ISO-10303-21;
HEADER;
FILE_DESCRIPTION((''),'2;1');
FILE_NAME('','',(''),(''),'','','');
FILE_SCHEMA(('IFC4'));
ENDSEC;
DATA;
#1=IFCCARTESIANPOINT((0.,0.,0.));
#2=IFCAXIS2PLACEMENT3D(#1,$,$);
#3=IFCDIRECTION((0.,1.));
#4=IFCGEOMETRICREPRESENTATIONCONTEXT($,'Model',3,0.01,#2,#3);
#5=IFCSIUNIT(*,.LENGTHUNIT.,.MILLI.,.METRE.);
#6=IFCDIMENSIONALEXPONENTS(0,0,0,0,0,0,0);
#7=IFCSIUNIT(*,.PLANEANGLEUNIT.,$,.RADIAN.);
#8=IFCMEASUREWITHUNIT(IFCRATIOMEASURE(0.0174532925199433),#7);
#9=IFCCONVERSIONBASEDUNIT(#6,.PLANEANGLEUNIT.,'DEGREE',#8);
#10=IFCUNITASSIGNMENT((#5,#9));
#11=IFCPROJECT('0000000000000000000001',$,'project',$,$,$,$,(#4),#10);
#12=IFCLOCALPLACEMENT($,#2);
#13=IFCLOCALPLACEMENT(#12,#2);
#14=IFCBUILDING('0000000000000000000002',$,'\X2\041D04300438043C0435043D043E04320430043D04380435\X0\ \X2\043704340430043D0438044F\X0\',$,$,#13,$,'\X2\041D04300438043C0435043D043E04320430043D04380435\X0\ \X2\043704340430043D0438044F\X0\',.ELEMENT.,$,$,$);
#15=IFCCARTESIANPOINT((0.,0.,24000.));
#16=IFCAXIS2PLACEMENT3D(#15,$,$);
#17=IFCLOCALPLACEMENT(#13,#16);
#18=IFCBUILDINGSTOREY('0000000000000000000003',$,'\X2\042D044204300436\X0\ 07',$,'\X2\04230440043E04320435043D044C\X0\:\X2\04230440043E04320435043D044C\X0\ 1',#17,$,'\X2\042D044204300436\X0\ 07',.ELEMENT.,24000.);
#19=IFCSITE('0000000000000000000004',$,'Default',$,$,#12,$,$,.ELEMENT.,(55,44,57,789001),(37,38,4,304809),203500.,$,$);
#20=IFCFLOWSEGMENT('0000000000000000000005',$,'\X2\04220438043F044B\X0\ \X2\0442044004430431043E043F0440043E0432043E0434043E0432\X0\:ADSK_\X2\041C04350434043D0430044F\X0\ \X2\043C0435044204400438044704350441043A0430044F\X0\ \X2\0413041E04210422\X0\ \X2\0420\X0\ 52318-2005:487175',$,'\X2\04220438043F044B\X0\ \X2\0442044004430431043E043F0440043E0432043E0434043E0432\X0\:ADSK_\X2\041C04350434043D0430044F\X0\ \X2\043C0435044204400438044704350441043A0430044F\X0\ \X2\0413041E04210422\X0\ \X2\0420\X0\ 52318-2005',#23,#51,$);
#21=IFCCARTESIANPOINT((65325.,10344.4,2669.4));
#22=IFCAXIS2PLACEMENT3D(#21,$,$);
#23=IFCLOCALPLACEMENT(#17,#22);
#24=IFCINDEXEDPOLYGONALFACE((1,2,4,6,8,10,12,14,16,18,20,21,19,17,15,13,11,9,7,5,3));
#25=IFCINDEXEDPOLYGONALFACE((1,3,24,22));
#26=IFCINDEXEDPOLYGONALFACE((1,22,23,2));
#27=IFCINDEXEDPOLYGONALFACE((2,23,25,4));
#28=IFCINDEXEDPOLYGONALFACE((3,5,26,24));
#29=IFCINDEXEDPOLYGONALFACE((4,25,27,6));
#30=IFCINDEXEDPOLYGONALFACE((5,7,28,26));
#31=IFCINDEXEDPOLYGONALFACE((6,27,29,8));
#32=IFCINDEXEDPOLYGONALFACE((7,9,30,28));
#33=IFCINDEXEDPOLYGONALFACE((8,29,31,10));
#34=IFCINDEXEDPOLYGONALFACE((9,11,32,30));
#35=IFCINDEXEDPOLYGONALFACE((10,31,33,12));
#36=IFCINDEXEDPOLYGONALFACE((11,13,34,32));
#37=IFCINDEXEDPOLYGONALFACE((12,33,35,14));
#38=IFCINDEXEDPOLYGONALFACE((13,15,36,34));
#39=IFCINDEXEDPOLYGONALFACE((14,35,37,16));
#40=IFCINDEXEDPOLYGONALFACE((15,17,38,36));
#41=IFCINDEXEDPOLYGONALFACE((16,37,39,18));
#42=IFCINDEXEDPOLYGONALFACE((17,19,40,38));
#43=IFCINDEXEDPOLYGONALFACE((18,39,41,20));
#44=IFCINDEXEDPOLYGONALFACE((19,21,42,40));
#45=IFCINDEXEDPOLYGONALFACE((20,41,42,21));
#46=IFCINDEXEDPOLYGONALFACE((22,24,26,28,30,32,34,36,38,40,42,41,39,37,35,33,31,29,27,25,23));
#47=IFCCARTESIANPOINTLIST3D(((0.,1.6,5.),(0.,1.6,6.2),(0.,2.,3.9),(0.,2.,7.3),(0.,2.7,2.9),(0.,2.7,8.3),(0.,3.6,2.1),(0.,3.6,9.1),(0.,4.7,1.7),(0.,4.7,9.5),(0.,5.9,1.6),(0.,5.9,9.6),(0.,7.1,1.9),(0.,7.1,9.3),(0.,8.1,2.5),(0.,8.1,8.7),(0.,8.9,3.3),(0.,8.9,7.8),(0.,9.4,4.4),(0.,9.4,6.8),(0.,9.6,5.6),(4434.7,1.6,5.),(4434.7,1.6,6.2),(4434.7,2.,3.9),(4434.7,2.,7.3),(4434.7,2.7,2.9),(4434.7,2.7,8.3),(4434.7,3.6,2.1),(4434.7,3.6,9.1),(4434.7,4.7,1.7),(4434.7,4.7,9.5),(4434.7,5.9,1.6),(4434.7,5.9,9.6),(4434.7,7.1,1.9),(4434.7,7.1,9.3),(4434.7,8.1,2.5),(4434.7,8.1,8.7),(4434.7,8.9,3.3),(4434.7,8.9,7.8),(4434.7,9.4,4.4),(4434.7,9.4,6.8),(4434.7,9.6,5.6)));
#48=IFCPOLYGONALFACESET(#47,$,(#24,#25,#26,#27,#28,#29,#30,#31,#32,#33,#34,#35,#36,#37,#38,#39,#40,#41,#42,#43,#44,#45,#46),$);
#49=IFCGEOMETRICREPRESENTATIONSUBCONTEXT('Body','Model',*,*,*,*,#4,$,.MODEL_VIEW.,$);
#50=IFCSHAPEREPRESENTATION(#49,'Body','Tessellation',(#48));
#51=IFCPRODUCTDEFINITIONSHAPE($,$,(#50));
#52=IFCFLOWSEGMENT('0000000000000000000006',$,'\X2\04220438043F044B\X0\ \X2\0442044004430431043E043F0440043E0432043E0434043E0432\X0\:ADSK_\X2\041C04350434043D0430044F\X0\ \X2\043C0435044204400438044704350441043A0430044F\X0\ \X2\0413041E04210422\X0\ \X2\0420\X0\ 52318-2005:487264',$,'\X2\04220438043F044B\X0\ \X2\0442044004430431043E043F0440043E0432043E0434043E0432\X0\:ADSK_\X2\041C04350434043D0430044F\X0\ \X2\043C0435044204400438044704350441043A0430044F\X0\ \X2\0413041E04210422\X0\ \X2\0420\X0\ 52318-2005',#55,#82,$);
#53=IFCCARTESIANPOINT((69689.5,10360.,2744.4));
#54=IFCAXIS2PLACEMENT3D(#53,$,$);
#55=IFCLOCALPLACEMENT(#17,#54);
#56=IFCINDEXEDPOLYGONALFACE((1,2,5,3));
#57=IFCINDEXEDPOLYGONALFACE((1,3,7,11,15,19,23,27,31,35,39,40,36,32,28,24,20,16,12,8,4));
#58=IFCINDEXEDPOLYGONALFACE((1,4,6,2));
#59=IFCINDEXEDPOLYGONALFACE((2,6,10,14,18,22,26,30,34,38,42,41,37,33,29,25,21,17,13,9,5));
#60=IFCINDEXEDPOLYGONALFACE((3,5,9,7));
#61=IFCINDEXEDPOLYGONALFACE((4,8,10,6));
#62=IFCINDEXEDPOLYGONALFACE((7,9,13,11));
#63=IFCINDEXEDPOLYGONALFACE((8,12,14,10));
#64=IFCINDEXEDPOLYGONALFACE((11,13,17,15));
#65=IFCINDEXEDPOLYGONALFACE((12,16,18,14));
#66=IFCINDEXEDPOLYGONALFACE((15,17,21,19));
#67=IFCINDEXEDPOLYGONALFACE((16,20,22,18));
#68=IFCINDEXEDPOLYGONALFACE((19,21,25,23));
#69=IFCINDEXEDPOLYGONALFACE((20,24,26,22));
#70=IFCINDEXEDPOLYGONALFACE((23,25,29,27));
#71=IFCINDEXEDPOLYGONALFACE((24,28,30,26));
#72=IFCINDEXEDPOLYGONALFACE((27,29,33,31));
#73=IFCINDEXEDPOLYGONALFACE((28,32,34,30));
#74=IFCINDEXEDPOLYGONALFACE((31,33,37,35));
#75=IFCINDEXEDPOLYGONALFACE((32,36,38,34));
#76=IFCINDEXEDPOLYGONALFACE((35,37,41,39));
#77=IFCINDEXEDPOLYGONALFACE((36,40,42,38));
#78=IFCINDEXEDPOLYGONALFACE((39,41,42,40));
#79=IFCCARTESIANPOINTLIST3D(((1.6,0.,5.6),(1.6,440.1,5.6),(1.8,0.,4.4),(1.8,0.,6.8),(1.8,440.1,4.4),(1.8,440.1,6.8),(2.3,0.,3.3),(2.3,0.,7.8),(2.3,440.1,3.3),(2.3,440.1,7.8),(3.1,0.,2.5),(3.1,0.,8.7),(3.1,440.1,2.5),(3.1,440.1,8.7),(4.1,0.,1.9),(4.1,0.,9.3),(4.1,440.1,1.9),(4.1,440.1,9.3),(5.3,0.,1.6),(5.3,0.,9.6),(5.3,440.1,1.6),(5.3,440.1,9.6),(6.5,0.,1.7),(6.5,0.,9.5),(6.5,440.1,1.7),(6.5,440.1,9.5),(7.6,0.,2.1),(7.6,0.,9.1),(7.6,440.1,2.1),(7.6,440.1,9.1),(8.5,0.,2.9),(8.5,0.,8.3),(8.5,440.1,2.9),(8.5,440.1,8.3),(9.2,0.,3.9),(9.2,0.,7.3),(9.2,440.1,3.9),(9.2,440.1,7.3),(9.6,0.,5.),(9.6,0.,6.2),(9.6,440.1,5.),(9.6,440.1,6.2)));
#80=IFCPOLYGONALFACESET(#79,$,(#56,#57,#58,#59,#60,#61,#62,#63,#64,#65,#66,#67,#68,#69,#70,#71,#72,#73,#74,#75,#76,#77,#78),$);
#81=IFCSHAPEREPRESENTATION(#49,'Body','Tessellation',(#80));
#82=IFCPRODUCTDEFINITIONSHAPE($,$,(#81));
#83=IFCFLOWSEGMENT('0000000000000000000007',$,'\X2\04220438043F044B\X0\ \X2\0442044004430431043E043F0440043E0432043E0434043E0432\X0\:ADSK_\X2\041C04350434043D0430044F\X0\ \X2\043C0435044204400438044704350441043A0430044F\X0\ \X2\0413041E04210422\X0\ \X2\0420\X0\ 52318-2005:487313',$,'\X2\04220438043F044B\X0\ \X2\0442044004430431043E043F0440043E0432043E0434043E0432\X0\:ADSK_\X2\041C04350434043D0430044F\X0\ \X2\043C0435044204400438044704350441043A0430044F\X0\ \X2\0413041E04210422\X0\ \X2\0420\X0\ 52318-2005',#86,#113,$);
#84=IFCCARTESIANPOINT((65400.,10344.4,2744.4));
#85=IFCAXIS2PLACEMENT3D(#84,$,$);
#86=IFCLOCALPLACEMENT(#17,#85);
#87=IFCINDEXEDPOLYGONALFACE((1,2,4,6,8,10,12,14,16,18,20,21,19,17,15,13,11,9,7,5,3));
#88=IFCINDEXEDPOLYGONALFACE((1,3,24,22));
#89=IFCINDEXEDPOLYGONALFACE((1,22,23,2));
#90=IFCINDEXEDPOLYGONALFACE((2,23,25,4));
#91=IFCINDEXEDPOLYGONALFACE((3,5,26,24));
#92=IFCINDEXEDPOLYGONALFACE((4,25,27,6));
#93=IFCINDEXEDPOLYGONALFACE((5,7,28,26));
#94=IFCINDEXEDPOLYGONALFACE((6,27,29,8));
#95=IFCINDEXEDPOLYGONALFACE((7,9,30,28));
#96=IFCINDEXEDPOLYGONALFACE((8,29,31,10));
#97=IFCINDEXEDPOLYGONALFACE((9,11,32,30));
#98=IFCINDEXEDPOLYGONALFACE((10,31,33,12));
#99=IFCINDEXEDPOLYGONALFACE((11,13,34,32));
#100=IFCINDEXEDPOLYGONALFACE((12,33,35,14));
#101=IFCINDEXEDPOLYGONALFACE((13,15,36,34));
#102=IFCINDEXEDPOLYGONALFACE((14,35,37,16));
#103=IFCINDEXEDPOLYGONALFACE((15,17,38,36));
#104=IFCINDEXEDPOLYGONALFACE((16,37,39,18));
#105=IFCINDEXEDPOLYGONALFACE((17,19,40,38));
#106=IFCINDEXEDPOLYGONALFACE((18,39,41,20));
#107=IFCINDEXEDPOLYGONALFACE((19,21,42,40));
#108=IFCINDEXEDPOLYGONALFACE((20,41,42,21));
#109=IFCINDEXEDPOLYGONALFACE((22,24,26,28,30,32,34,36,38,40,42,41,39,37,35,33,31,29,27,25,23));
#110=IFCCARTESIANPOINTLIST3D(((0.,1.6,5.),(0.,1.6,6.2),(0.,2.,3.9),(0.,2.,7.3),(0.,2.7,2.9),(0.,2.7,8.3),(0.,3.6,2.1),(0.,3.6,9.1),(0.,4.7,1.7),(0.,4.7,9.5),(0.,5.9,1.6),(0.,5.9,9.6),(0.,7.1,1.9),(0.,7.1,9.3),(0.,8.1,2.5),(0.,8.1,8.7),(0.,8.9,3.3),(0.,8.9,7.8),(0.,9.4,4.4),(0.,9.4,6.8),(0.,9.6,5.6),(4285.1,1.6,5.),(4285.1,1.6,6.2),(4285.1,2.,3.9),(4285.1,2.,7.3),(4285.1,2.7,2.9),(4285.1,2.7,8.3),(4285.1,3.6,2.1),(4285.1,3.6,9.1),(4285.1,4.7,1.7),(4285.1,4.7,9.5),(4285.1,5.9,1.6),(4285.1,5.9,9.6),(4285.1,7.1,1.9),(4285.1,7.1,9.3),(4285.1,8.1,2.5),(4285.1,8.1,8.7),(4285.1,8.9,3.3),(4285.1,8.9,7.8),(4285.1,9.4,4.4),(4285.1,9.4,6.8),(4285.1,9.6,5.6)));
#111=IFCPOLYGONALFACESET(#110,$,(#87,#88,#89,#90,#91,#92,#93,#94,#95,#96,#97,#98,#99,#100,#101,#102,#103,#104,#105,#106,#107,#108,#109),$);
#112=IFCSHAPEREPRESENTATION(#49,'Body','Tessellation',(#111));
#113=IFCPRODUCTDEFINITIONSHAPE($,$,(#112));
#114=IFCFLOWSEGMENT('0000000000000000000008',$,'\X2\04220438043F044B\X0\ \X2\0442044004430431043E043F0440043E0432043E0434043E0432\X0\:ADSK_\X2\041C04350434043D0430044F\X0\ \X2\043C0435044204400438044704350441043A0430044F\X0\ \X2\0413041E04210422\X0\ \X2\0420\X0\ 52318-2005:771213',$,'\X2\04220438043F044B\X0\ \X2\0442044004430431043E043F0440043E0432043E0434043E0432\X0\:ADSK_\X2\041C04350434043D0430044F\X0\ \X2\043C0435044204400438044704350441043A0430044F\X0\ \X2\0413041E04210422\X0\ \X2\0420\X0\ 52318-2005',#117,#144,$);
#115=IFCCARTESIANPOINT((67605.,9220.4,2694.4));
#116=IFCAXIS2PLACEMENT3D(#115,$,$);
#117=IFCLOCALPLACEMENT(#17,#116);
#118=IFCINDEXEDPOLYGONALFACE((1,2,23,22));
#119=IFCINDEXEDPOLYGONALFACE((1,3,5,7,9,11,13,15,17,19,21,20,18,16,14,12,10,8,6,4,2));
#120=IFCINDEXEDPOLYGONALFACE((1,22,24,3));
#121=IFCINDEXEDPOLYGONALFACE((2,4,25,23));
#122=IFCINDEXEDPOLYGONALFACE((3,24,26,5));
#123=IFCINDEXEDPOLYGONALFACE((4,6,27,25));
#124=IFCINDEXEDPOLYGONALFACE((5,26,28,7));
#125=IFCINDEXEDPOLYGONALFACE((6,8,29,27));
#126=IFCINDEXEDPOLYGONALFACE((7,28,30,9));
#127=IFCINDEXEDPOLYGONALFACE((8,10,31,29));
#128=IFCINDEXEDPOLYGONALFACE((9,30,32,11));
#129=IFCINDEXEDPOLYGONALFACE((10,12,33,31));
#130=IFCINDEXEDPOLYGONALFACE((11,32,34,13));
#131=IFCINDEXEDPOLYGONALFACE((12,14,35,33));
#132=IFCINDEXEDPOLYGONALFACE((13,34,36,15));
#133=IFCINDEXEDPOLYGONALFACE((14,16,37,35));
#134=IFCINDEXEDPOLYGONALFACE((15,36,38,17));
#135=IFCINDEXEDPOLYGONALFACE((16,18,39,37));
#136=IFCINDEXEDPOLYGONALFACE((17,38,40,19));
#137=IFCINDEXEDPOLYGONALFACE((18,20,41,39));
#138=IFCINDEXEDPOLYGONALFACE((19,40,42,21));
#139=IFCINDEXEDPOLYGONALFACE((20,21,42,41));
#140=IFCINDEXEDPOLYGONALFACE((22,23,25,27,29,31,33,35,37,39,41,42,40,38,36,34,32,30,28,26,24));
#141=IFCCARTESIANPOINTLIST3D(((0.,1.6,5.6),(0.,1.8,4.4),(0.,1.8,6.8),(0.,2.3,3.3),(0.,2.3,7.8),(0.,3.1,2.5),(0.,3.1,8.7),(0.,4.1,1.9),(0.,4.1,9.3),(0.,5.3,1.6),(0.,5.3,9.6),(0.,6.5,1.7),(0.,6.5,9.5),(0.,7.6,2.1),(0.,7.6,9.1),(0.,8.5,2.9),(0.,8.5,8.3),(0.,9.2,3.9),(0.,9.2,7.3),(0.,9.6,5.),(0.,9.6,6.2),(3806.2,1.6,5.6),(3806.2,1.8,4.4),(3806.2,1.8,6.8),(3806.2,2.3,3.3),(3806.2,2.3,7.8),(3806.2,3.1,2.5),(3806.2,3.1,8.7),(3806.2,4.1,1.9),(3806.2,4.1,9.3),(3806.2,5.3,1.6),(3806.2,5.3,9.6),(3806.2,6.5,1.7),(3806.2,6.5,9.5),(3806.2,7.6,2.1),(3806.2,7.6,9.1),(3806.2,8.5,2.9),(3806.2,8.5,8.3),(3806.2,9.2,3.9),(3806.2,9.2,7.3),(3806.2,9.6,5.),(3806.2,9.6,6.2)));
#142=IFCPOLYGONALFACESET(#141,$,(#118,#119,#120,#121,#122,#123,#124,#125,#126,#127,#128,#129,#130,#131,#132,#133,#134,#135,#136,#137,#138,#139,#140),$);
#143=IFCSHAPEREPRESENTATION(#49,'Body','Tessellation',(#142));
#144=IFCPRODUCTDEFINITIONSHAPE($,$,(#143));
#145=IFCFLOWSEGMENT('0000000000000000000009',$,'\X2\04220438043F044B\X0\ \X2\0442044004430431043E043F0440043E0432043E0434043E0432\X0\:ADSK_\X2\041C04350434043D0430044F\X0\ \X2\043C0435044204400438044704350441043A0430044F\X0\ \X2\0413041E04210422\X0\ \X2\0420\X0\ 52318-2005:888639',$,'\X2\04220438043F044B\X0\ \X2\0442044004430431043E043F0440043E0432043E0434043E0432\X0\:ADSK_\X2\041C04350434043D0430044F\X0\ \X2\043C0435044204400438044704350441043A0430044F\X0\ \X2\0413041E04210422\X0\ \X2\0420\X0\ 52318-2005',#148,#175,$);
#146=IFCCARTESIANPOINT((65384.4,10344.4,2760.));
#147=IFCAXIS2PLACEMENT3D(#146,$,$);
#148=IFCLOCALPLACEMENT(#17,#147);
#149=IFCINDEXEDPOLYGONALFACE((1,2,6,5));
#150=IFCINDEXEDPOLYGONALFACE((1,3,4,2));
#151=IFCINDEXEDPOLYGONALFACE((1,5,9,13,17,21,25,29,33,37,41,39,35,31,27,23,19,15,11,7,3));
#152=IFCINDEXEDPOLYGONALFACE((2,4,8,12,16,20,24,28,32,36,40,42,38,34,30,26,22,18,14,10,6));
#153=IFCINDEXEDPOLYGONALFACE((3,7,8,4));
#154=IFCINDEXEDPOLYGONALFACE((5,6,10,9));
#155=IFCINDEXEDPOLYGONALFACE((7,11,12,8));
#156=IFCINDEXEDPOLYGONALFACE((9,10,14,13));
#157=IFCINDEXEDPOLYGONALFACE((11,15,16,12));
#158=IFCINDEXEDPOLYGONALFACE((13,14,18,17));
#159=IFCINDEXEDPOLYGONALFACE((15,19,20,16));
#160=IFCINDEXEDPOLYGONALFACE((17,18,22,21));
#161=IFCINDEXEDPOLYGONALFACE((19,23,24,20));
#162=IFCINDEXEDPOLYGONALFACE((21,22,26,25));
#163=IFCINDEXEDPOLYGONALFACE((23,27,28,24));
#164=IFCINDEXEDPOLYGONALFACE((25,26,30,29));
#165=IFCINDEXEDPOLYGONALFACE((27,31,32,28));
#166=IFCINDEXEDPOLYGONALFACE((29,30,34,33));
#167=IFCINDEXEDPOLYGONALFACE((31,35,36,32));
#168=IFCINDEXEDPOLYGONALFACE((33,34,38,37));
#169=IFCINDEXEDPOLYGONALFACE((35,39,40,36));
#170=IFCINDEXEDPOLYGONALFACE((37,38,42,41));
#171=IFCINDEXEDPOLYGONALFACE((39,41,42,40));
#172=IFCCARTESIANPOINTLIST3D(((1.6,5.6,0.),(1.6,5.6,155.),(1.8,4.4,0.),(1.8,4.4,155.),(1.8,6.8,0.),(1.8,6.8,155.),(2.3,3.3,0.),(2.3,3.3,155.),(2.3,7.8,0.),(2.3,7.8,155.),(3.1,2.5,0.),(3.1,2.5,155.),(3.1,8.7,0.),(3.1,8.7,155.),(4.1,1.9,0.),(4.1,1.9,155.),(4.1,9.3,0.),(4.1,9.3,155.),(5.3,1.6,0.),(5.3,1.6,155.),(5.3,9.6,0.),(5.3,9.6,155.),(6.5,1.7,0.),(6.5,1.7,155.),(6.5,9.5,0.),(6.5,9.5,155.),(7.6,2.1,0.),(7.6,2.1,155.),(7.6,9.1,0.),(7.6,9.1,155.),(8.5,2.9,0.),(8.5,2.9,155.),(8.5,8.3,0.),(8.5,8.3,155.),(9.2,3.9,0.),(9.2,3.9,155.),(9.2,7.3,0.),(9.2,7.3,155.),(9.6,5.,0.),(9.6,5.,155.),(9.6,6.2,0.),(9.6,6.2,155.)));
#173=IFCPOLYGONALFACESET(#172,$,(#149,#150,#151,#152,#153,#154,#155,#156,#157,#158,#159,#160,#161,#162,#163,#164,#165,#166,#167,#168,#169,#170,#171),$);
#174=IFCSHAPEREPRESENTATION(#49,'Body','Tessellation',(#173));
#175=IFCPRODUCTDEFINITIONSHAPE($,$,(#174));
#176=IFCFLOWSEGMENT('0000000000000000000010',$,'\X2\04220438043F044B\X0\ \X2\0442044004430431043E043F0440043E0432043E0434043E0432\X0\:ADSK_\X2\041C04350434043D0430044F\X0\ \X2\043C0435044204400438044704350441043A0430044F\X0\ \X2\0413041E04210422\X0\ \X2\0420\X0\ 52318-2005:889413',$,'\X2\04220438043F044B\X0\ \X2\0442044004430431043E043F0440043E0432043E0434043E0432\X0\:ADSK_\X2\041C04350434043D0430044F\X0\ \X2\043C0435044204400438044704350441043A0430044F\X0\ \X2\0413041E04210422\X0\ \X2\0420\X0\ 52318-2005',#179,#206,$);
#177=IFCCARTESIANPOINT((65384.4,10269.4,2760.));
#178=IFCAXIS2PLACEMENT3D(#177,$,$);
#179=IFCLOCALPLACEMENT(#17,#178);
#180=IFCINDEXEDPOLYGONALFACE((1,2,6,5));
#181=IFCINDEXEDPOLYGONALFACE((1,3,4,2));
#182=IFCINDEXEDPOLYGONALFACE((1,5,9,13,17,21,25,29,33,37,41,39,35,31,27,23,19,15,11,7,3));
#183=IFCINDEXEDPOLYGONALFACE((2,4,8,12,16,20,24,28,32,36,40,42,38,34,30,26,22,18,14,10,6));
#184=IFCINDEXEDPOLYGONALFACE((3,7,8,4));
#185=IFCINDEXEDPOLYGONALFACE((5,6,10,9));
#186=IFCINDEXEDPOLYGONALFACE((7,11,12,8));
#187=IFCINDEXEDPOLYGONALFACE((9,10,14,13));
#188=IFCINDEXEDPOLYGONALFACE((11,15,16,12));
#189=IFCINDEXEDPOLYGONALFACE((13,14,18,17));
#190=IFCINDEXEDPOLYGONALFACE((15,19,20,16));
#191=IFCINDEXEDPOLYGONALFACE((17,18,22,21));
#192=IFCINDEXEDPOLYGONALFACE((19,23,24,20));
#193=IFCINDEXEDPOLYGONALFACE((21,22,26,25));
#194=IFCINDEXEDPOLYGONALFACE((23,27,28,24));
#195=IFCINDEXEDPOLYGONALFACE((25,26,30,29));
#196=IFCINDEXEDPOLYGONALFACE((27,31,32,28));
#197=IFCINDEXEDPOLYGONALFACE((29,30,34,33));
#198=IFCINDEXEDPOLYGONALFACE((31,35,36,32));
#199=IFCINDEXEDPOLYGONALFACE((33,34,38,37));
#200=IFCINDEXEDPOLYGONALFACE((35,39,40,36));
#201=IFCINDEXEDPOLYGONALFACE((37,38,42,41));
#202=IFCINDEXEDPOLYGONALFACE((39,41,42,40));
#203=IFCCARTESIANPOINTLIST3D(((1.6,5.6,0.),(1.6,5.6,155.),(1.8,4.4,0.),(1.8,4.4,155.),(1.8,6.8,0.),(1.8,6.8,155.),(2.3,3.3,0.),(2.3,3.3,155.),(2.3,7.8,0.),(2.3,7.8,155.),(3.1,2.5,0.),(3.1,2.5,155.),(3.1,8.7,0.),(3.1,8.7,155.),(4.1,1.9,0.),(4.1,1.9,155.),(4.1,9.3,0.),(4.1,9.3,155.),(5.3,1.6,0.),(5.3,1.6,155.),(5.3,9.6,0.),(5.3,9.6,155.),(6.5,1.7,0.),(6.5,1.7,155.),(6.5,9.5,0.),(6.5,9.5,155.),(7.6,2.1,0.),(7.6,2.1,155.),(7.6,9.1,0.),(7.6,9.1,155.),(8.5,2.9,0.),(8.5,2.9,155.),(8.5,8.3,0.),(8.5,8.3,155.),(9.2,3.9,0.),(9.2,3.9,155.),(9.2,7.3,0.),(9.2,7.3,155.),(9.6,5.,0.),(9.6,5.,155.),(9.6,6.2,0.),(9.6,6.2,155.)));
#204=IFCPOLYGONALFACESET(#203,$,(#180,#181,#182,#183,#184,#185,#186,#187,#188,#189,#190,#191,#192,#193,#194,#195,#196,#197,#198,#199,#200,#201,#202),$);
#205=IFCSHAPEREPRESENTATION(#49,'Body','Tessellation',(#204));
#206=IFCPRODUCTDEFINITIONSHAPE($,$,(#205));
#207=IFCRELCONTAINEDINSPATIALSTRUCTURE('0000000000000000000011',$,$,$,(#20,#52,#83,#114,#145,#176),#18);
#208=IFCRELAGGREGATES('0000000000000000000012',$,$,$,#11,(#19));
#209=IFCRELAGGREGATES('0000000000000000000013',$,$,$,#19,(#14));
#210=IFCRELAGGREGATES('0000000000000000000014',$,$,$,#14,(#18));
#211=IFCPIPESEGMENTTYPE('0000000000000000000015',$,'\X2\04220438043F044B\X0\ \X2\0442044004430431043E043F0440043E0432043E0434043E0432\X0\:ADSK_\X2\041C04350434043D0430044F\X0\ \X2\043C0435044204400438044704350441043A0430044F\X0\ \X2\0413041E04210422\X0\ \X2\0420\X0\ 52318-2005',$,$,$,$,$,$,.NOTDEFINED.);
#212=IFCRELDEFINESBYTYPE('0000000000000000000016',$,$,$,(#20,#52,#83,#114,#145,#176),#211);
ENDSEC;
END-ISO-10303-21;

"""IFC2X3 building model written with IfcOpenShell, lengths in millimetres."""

from ifc_helpers import new_model, entity, si_unit, converted_unit, direction, frame, frame_2d, origin, origin_2d_with_axis, place, context, subcontext, project, spatial, circle, extrude, type_object, element, save


model = new_model("IFC2X3")

# Units and contexts
model_context = context("Model", 3, precision=0.01, world=origin(), true_north=direction((0.0, 1.0)))
body_context = subcontext(model_context, "Body", "Model", "MODEL_VIEW")
ifc_project = project(units=[si_unit("LENGTHUNIT", "METRE", prefix="MILLI"), converted_unit("PLANEANGLEUNIT", "DEGREE", entity("IfcRatioMeasure", 0.0174532925199433), si_unit("PLANEANGLEUNIT", "RADIAN"), dimensions=[0, 0, 0, 0, 0, 0, 0])], contexts=[model_context])

# Site, building, storey
site_placement = place(None, frame((0.0, 0.0, 0.0)))
site = spatial("IfcSite", under=ifc_project, at=site_placement, Name="Default", CompositionType="ELEMENT", RefLatitude=(55, 44, 57, 789001), RefLongitude=(37, 38, 4, 304809), RefElevation=203500.0)
building_placement = place(site_placement, origin())
building = spatial("IfcBuilding", under=site, at=building_placement, Name="Наименование здания", LongName="Наименование здания", CompositionType="ELEMENT")
storey_placement = place(building_placement, frame((0.0, 0.0, 24000.0)))
storey = spatial("IfcBuildingStorey", under=building, at=storey_placement, Name="Этаж 07", ObjectType="Уровень:Уровень 1", LongName="Этаж 07", CompositionType="ELEMENT", Elevation=24000.0)

# Flow segments
pipe_segment_type = type_object("IfcPipeSegmentType", Name="Типы трубопроводов:ADSK_Медная метрическая ГОСТ Р 52318-2005", PredefinedType="NOTDEFINED")
flow_segment_1_placement = place(storey_placement, frame((65325.0, 10344.4, 2669.4)))
element("IfcFlowSegment", 1, at=flow_segment_1_placement, inside=storey, type_object=pipe_segment_type, Name="Типы трубопроводов:ADSK_Медная метрическая ГОСТ Р 52318-2005:487175", ObjectType="Типы трубопроводов:ADSK_Медная метрическая ГОСТ Р 52318-2005", context=body_context, shape_type="SweptSolid", body=[
    extrude(circle(Radius=4.0, at=frame_2d((0.0, 0.0), x_axis=(1.0, 0.0))), frame((0.0, 5.6, 5.6), z_axis=(1.0, 0.0, 0.0), x_axis=(0.0, 1.0, 0.0)), (0.0, 0.0, 1.0), 4434.7),
])
flow_segment_2_placement = place(storey_placement, frame((69689.5, 10360.0, 2744.4)))
element("IfcFlowSegment", 2, at=flow_segment_2_placement, inside=storey, type_object=pipe_segment_type, Name="Типы трубопроводов:ADSK_Медная метрическая ГОСТ Р 52318-2005:487264", ObjectType="Типы трубопроводов:ADSK_Медная метрическая ГОСТ Р 52318-2005", context=body_context, shape_type="SweptSolid", body=[
    extrude(circle(Radius=4.0, at=frame_2d((0.0, 0.0), x_axis=(1.0, 0.0))), frame((5.6, 0.0, 5.6), z_axis=(0.0, 1.0, 0.0), x_axis=(-1.0, 0.0, 0.0)), (0.0, 0.0, 1.0), 440.1),
])
flow_segment_3_placement = place(storey_placement, frame((65400.0, 10344.4, 2744.4)))
element("IfcFlowSegment", 3, at=flow_segment_3_placement, inside=storey, type_object=pipe_segment_type, Name="Типы трубопроводов:ADSK_Медная метрическая ГОСТ Р 52318-2005:487313", ObjectType="Типы трубопроводов:ADSK_Медная метрическая ГОСТ Р 52318-2005", context=body_context, shape_type="SweptSolid", body=[
    extrude(circle(Radius=4.0, at=frame_2d((0.0, 0.0), x_axis=(1.0, 0.0))), frame((0.0, 5.6, 5.6), z_axis=(1.0, 0.0, 0.0), x_axis=(0.0, 1.0, 0.0)), (0.0, 0.0, 1.0), 4285.1),
])
flow_segment_4_placement = place(storey_placement, frame((67605.0, 9220.4, 2694.4)))
element("IfcFlowSegment", 4, at=flow_segment_4_placement, inside=storey, type_object=pipe_segment_type, Name="Типы трубопроводов:ADSK_Медная метрическая ГОСТ Р 52318-2005:771213", ObjectType="Типы трубопроводов:ADSK_Медная метрическая ГОСТ Р 52318-2005", context=body_context, shape_type="SweptSolid", body=[
    extrude(circle(Radius=4.0, at=origin_2d_with_axis()), frame((0.0, 5.6, 5.6), z_axis=(1.0, 0.0, 0.0), x_axis=(0.0, -1.0, 0.0)), (0.0, 0.0, 1.0), 3806.2),
])
flow_segment_5_placement = place(storey_placement, frame((65384.4, 10344.4, 2760.0)))
element("IfcFlowSegment", 5, at=flow_segment_5_placement, inside=storey, type_object=pipe_segment_type, Name="Типы трубопроводов:ADSK_Медная метрическая ГОСТ Р 52318-2005:888639", ObjectType="Типы трубопроводов:ADSK_Медная метрическая ГОСТ Р 52318-2005", context=body_context, shape_type="SweptSolid", body=[
    extrude(circle(Radius=4.0, at=origin_2d_with_axis()), frame((5.6, 5.6, 0.0), z_axis=(0.0, 0.0, 1.0), x_axis=(-1.0, 0.0, 0.0)), (0.0, 0.0, 1.0), 155.0),
])
flow_segment_6_placement = place(storey_placement, frame((65384.4, 10269.4, 2760.0)))
element("IfcFlowSegment", 6, at=flow_segment_6_placement, inside=storey, type_object=pipe_segment_type, Name="Типы трубопроводов:ADSK_Медная метрическая ГОСТ Р 52318-2005:889413", ObjectType="Типы трубопроводов:ADSK_Медная метрическая ГОСТ Р 52318-2005", context=body_context, shape_type="SweptSolid", body=[
    extrude(circle(Radius=4.0, at=origin_2d_with_axis()), frame((5.6, 5.6, 0.0), z_axis=(0.0, 0.0, 1.0), x_axis=(-1.0, 0.0, 0.0)), (0.0, 0.0, 1.0), 155.0),
])

save(model, "model.ifc")
